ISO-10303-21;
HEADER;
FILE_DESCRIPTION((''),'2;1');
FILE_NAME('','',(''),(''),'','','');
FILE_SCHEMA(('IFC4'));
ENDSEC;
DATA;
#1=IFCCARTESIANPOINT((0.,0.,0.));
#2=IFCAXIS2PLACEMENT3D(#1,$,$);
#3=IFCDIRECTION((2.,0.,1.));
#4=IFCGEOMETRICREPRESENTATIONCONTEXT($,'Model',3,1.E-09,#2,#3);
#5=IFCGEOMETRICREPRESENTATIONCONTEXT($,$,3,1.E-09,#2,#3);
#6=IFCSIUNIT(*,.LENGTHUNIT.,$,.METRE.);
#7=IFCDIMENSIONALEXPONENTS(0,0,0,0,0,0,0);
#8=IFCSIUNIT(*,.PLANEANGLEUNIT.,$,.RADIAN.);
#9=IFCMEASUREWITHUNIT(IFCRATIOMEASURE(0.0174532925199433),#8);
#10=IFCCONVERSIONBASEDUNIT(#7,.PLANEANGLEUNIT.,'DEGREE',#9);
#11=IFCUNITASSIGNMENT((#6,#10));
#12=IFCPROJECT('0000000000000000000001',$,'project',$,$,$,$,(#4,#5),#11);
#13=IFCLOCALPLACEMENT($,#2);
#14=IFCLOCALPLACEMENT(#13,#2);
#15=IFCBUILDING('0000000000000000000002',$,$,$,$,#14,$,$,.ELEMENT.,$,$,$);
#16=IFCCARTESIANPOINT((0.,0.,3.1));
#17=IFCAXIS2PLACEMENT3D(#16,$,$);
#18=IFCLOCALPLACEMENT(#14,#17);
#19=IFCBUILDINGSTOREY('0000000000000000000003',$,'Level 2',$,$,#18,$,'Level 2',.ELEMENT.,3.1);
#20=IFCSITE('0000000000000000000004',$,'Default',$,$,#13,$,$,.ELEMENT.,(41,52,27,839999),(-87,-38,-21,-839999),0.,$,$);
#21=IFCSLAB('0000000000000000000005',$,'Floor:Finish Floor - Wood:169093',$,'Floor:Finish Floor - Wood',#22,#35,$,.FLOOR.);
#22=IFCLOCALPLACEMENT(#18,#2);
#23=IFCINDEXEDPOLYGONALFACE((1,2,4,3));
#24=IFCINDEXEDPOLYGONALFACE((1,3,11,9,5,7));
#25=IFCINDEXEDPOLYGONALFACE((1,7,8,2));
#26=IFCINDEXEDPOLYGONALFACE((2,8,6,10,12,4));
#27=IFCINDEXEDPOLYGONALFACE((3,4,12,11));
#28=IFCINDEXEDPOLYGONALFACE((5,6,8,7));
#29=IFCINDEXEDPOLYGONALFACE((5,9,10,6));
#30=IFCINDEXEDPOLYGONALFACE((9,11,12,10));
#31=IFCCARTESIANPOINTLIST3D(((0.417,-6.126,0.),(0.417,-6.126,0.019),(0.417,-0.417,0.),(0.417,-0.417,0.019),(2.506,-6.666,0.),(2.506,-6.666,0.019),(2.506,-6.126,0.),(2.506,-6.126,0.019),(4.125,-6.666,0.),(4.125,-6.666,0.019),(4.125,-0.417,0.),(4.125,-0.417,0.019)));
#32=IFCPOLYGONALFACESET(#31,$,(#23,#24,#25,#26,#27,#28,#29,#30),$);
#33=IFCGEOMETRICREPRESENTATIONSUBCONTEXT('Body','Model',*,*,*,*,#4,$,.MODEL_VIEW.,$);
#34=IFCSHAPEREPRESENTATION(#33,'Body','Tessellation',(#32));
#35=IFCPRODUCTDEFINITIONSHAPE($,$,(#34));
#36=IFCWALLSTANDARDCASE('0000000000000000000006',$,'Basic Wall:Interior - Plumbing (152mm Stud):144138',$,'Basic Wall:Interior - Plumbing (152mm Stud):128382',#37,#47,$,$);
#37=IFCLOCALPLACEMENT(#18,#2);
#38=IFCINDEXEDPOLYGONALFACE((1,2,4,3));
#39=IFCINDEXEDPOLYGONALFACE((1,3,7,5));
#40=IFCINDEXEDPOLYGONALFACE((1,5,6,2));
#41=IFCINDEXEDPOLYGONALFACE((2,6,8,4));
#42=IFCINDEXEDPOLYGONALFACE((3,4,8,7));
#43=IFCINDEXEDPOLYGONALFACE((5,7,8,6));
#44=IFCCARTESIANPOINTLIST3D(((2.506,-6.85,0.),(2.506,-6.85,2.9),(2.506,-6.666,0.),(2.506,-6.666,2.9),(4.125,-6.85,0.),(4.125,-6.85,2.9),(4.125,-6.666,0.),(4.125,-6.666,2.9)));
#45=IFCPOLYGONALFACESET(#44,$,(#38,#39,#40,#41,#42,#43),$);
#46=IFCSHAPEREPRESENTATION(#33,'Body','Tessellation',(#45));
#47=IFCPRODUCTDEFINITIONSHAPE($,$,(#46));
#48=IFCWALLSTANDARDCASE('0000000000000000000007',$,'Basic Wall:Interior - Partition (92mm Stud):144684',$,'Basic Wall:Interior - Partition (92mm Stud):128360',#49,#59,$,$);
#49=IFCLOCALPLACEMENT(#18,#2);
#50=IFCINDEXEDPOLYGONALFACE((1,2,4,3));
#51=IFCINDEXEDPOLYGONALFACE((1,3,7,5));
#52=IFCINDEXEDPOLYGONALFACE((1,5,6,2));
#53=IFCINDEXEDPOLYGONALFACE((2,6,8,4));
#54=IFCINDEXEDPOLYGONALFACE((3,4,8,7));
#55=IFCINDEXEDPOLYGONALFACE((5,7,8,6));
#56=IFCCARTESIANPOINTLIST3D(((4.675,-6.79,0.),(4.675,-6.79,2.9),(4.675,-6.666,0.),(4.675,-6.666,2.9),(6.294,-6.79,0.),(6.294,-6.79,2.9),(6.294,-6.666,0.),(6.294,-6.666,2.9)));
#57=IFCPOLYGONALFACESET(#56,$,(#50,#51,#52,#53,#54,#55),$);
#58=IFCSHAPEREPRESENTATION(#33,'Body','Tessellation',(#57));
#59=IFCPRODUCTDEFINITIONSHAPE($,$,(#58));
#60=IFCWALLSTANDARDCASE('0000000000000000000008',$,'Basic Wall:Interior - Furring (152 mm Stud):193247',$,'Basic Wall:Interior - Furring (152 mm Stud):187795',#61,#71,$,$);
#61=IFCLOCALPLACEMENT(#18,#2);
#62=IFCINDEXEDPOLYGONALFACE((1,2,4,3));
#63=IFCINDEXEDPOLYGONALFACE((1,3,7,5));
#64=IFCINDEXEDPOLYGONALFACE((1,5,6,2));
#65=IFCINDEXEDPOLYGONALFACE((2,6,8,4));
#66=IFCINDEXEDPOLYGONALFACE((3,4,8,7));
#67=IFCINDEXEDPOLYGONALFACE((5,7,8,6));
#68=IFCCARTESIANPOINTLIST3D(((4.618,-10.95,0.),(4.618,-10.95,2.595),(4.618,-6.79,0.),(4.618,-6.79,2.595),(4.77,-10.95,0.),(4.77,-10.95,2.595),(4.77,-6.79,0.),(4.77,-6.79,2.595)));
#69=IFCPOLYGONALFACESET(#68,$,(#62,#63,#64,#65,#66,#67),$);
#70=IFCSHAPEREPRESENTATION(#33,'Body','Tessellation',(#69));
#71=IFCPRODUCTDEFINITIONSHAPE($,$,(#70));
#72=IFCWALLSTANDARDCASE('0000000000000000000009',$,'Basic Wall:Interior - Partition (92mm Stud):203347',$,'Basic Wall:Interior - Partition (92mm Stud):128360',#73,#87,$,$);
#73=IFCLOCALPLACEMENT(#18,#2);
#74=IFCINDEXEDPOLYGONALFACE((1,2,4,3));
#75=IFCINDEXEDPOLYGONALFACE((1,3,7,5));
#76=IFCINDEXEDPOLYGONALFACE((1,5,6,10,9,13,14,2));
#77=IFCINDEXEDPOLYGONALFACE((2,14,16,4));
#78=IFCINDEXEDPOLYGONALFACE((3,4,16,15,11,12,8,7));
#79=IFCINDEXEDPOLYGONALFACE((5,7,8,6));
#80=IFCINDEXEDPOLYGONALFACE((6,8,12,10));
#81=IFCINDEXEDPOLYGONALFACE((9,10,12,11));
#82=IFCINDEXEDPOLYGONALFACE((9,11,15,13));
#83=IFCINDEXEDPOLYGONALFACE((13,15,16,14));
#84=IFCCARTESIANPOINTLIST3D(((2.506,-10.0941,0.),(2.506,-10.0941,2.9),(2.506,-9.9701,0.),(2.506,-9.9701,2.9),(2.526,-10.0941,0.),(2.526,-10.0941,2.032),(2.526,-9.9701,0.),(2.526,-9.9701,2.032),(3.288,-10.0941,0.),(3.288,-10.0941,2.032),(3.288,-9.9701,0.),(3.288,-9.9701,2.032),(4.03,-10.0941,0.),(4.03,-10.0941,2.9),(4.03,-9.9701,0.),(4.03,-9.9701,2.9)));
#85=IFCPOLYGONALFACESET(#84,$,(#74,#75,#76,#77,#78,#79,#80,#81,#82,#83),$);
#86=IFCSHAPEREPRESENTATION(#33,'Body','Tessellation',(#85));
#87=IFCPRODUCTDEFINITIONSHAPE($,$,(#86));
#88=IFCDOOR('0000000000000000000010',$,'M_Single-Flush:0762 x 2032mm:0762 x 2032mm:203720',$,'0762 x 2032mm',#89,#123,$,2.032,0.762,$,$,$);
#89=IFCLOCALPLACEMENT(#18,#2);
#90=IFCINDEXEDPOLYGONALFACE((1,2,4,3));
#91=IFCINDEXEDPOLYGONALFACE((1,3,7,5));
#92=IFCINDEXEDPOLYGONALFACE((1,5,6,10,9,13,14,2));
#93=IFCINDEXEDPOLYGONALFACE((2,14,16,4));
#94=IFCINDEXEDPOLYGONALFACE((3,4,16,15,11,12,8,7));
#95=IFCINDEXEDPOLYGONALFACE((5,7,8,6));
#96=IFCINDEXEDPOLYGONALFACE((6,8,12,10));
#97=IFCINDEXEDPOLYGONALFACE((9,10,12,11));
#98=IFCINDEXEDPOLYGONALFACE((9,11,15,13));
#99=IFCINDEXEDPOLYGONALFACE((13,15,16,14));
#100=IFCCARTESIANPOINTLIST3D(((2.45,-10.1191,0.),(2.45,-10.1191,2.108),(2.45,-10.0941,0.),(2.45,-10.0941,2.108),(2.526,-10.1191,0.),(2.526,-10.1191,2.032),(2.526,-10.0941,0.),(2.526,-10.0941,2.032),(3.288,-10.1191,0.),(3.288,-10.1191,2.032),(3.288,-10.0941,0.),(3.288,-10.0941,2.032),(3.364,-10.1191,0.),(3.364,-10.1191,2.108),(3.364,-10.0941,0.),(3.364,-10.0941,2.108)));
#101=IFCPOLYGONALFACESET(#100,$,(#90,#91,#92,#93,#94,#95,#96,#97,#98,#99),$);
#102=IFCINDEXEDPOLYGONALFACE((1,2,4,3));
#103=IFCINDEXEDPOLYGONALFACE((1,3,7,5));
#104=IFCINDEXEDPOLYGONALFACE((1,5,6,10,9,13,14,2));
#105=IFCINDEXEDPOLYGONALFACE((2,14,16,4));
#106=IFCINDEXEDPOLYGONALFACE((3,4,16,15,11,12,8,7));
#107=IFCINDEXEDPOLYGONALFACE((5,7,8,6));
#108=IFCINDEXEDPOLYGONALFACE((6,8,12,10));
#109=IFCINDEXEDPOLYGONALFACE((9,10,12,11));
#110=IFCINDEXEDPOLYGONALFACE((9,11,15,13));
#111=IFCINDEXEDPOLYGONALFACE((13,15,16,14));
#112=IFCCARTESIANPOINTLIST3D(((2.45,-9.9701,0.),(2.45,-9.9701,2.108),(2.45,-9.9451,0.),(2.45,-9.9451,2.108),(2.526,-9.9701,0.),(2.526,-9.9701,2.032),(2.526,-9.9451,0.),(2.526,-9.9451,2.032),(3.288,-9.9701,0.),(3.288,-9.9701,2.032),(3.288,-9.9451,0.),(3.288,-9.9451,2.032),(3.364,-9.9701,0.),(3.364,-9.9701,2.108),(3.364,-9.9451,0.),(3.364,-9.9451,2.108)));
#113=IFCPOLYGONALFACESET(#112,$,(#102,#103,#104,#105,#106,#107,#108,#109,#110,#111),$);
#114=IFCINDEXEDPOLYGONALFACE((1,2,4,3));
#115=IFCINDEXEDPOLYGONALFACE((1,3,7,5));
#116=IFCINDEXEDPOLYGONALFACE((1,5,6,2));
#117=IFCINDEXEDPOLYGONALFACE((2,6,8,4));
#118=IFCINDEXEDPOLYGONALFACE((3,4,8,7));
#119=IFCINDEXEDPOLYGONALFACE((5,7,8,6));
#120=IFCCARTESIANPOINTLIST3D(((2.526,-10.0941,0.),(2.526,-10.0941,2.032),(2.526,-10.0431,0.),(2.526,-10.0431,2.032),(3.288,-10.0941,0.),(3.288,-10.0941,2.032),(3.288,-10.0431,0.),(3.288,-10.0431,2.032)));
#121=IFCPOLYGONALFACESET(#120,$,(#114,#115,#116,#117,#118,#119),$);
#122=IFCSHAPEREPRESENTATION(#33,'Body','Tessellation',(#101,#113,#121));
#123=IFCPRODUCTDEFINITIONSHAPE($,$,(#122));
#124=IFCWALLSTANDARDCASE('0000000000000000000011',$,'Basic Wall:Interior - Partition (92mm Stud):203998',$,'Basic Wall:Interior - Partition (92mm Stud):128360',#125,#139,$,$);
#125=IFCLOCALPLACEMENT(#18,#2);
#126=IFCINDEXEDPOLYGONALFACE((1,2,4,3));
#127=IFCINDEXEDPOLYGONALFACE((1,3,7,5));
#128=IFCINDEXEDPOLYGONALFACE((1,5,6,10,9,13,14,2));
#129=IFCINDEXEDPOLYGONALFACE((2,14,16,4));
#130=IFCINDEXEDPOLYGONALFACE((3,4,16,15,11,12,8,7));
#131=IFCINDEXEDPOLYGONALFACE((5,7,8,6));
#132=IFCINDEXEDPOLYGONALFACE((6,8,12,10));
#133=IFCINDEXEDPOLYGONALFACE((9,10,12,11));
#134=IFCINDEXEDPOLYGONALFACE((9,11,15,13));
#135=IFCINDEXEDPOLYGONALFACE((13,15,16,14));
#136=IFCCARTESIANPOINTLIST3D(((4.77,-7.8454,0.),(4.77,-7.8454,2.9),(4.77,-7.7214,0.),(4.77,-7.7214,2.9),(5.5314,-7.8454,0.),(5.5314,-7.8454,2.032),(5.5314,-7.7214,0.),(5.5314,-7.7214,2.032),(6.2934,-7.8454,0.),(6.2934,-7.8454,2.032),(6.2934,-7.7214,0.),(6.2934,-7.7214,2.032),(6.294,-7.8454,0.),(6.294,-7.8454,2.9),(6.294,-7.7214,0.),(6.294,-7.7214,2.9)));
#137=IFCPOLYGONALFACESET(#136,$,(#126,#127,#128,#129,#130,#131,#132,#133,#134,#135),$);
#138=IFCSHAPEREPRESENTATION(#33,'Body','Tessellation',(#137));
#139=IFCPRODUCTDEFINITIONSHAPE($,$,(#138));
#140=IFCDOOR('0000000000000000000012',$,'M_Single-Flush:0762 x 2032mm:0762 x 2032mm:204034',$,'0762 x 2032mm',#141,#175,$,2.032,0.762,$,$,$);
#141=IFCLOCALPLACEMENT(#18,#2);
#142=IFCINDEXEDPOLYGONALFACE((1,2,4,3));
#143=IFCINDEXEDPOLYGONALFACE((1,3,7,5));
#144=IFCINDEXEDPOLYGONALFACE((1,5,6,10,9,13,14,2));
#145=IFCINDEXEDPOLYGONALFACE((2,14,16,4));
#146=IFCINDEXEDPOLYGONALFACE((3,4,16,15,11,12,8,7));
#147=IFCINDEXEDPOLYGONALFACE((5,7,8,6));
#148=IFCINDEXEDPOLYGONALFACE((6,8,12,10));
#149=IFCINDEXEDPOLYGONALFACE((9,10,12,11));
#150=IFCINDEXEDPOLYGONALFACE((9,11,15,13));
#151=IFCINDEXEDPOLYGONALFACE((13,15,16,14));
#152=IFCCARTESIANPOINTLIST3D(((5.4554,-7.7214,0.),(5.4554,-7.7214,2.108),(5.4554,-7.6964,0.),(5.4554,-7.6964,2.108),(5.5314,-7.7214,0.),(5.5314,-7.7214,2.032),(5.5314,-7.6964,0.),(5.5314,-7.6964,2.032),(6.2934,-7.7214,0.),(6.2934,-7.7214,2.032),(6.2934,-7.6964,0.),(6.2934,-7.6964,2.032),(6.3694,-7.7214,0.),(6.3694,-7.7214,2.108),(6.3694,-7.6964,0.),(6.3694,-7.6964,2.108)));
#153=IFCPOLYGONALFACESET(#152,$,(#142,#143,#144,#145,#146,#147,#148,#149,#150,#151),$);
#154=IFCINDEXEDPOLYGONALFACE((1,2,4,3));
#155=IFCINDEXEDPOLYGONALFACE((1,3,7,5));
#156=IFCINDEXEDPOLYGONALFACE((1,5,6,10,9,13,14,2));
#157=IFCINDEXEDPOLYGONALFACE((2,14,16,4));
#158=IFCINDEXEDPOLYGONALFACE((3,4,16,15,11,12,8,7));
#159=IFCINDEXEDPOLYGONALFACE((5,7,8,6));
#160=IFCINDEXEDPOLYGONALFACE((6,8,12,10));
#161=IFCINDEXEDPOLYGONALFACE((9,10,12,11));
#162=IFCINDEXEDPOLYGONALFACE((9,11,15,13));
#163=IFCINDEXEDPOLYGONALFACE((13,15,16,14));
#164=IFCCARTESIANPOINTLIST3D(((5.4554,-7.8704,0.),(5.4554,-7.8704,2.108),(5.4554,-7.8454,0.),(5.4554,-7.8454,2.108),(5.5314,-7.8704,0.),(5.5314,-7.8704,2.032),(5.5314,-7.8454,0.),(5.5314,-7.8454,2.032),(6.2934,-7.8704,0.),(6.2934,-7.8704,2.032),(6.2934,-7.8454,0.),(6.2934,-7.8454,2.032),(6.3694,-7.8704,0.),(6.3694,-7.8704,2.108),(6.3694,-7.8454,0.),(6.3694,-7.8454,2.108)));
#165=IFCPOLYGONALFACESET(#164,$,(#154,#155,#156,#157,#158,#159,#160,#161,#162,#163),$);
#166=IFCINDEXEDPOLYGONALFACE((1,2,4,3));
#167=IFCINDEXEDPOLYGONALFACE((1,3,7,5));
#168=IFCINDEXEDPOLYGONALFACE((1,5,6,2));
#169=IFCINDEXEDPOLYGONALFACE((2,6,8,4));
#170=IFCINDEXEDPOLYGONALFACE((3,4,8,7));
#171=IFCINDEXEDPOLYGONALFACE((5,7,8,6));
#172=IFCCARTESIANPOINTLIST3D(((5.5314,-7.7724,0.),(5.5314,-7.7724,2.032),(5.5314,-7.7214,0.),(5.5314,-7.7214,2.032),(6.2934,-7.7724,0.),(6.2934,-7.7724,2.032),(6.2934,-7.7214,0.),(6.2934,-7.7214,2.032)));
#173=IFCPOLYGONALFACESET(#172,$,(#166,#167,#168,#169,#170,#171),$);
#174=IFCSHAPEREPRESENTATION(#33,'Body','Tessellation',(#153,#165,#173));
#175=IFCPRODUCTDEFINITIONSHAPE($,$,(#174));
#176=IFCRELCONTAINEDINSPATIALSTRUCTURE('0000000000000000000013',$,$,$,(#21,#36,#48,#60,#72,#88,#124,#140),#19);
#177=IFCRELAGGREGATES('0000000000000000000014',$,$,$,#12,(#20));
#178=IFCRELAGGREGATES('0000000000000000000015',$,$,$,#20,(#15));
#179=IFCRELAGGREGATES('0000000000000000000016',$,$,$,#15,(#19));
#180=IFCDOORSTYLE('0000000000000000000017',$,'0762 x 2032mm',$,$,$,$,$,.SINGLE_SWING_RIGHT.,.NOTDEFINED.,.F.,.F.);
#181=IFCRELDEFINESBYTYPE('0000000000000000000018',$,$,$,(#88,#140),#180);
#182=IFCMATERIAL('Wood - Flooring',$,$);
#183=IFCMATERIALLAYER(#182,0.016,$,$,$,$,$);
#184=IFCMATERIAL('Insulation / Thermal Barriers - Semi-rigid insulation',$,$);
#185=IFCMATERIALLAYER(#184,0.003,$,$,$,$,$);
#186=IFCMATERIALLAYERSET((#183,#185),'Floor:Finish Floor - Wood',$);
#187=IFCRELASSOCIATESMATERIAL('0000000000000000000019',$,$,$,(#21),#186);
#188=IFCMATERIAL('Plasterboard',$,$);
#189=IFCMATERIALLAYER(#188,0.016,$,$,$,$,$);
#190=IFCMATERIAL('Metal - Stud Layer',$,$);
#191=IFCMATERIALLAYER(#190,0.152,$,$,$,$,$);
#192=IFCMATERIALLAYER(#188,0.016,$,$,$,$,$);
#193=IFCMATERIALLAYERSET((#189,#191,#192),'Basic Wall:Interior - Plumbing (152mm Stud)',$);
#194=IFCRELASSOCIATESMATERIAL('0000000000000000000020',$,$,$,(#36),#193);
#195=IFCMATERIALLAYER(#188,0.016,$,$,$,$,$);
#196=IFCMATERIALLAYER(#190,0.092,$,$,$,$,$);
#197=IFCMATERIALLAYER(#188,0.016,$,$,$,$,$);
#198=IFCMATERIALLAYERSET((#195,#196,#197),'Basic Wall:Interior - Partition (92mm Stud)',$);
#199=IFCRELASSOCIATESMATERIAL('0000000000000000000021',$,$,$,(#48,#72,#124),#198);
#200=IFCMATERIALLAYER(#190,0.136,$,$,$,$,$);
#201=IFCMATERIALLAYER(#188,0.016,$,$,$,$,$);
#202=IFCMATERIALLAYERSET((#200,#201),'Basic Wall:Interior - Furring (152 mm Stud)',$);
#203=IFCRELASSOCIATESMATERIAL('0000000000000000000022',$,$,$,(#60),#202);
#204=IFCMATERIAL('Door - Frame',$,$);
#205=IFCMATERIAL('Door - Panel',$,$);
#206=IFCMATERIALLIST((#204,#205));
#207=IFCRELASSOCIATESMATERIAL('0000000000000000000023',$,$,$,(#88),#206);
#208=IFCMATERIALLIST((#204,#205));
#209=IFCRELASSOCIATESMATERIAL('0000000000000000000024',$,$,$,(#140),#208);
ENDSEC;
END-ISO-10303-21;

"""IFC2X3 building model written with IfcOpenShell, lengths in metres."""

from ifc_helpers import new_model, entity, si_unit, converted_unit, direction, frame, frame_2d, origin, origin_2d_with_axis, place, context, subcontext, project, spatial, polyline, rectangle, outline, extrude, source, transform, mapped, material, material_list, layer, layer_set, layer_usage, type_object, type_shapes, element, fill, save


model = new_model("IFC2X3")

# Units and contexts
model_context = context("Model", 3, precision=1e-09, world=origin(), true_north=direction((2.0, 0.0, 1.0)))
context_of_model = context(None, 3, precision=1e-09, world=origin(), true_north=direction((2.0, 0.0, 1.0)))
body_context = subcontext(model_context, "Body", "Model", "MODEL_VIEW")
ifc_project = project(units=[si_unit("LENGTHUNIT", "METRE"), converted_unit("PLANEANGLEUNIT", "DEGREE", entity("IfcRatioMeasure", 0.0174532925199433), si_unit("PLANEANGLEUNIT", "RADIAN"), dimensions=[0, 0, 0, 0, 0, 0, 0])], contexts=[model_context, context_of_model])

# Site, building, storey
site_placement = place(None, origin())
site = spatial("IfcSite", under=ifc_project, at=site_placement, Name="Default", CompositionType="ELEMENT", RefLatitude=(41, 52, 27, 839999), RefLongitude=(-87, -38, -21, -839999), RefElevation=0.0)
building_placement = place(site_placement, origin())
building = spatial("IfcBuilding", under=site, at=building_placement, CompositionType="ELEMENT")
storey_placement = place(building_placement, frame((0.0, 0.0, 3.1)))
storey = spatial("IfcBuildingStorey", under=building, at=storey_placement, Name="Level 2", LongName="Level 2", CompositionType="ELEMENT", Elevation=3.1)

# Slab
ifc_material_1 = material(Name="Wood - Flooring")
ifc_layer_1 = layer(ifc_material_1, 0.016)
ifc_material_2 = material(Name="Insulation / Thermal Barriers - Semi-rigid insulation")
ifc_layer_2 = layer(ifc_material_2, 0.003)
ifc_layer_set_1 = layer_set([ifc_layer_1, ifc_layer_2], Name="Floor:Finish Floor - Wood")
ifc_layer_usage_1 = layer_usage(ifc_layer_set_1, "AXIS3", "POSITIVE", 0.0)
slab_placement = place(storey_placement, frame((0.417, -6.666, 0.0)))
element("IfcSlab", 1, at=slab_placement, inside=storey, material=ifc_layer_usage_1, Name="Floor:Finish Floor - Wood:169093", ObjectType="Floor:Finish Floor - Wood", PredefinedType="FLOOR", context=body_context, shape_type="SweptSolid", body=[
    extrude(outline(polyline([(1.854, 3.1245), (-1.854, 3.1245), (-1.854, -3.1245), (-0.235, -3.1245), (-0.235, -2.5845), (1.854, -2.5845), (1.854, 3.1245)])), frame((1.854, 3.1245, 0.019), z_axis=(0.0, 0.0, -1.0), x_axis=(-1.0, 0.0, 0.0)), (0.0, 0.0, 1.0), 0.019),
])

# Walls
ifc_material_3 = material(Name="Plasterboard")
ifc_layer_3 = layer(ifc_material_3, 0.016)
ifc_material_4 = material(Name="Metal - Stud Layer")
ifc_layer_4 = layer(ifc_material_4, 0.152)
ifc_layer_5 = layer(ifc_material_3, 0.016)
ifc_layer_set_2 = layer_set([ifc_layer_3, ifc_layer_4, ifc_layer_5], Name="Basic Wall:Interior - Plumbing (152mm Stud)")
ifc_layer_usage_2 = layer_usage(ifc_layer_set_2, "AXIS2", "NEGATIVE", 0.092)
wall_1_placement = place(storey_placement, frame((2.506, -6.758, 0.0)))
element("IfcWallStandardCase", 2, at=wall_1_placement, inside=storey, material=ifc_layer_usage_2, Name="Basic Wall:Interior - Plumbing (152mm Stud):144138", ObjectType="Basic Wall:Interior - Plumbing (152mm Stud):128382", context=body_context, shape_type="SweptSolid", body=[
    extrude(rectangle(XDim=1.619, YDim=0.184, at=frame_2d((0.8095, 0.0), x_axis=(-1.0, 0.0))), origin(), (0.0, 0.0, 1.0), 2.9),
])
ifc_layer_6 = layer(ifc_material_3, 0.016)
ifc_layer_7 = layer(ifc_material_4, 0.092)
ifc_layer_8 = layer(ifc_material_3, 0.016)
ifc_layer_set_3 = layer_set([ifc_layer_6, ifc_layer_7, ifc_layer_8], Name="Basic Wall:Interior - Partition (92mm Stud)")
ifc_layer_usage_3 = layer_usage(ifc_layer_set_3, "AXIS2", "NEGATIVE", 0.062)
wall_2_placement = place(storey_placement, frame((4.675, -6.728, 0.0)))
element("IfcWallStandardCase", 3, at=wall_2_placement, inside=storey, material=ifc_layer_usage_3, Name="Basic Wall:Interior - Partition (92mm Stud):144684", ObjectType="Basic Wall:Interior - Partition (92mm Stud):128360", context=body_context, shape_type="SweptSolid", body=[
    extrude(rectangle(XDim=1.619, YDim=0.124, at=frame_2d((0.8095, 0.0), x_axis=(-1.0, 0.0))), origin(), (0.0, 0.0, 1.0), 2.9),
])
ifc_layer_9 = layer(ifc_material_4, 0.136)
ifc_layer_10 = layer(ifc_material_3, 0.016)
ifc_layer_set_4 = layer_set([ifc_layer_9, ifc_layer_10], Name="Basic Wall:Interior - Furring (152 mm Stud)")
ifc_layer_usage_4 = layer_usage(ifc_layer_set_4, "AXIS2", "POSITIVE", -0.076)
wall_3_placement = place(storey_placement, frame((4.694, -6.79, 0.0), z_axis=(0.0, 0.0, 1.0), x_axis=(0.0, -1.0, 0.0)))
element("IfcWallStandardCase", 4, at=wall_3_placement, inside=storey, material=ifc_layer_usage_4, Name="Basic Wall:Interior - Furring (152 mm Stud):193247", ObjectType="Basic Wall:Interior - Furring (152 mm Stud):187795", context=body_context, shape_type="SweptSolid", body=[
    extrude(rectangle(XDim=4.16, YDim=0.152, at=frame_2d((2.08, 0.0), x_axis=(-1.0, 0.0))), origin(), (0.0, 0.0, 1.0), 2.595),
])

# Walls, openings, doors
ifc_layer_usage_5 = layer_usage(ifc_layer_set_3, "AXIS2", "NEGATIVE", 0.062)
wall_4_placement = place(storey_placement, frame((4.03, -10.0321, 0.0), z_axis=(0.0, 0.0, 1.0), x_axis=(-1.0, 0.0, 0.0)))
wall_4 = element("IfcWallStandardCase", 5, at=wall_4_placement, inside=storey, material=ifc_layer_usage_5, Name="Basic Wall:Interior - Partition (92mm Stud):203347", ObjectType="Basic Wall:Interior - Partition (92mm Stud):128360", context=body_context, shape_type="SweptSolid", body=[
    extrude(rectangle(XDim=1.524, YDim=0.124, at=frame_2d((0.762, 0.0), x_axis=(-1.0, 0.0))), origin(), (0.0, 0.0, 1.0), 2.9),
])
opening_1_placement = place(wall_4_placement, frame((0.742, -0.062, 0.0)))
opening_1 = element("IfcOpeningElement", 6, at=opening_1_placement, cuts=wall_4, ObjectType="Opening", context=body_context, shape_type="SweptSolid", body=[
    extrude(rectangle(XDim=0.762, YDim=2.032, at=frame_2d((1.016, 0.381), x_axis=(0.0, 1.0))), frame((0.0, 0.0, 0.0), z_axis=(0.0, 1.0, 0.0), x_axis=(0.0, 0.0, 1.0)), (0.0, 0.0, 1.0), 0.124),
])
ifc_material_5 = material(Name="Door - Frame")
ifc_material_6 = material(Name="Door - Panel")
ifc_material_list_1 = material_list([ifc_material_5, ifc_material_6])
door_style = type_object("IfcDoorStyle", Name="0762 x 2032mm", ConstructionType="NOTDEFINED", OperationType="SINGLE_SWING_RIGHT", ParameterTakesPrecedence=False, Sizeable=False)
shared_shape_1 = source(origin(), body_context, "Body", "SweptSolid", [
    extrude(outline(polyline([(-0.457, -1.073), (0.457, -1.073), (0.457, 1.035), (0.381, 1.035), (0.381, -0.997), (-0.381, -0.997), (-0.381, 1.035), (-0.457, 1.035), (-0.457, -1.073)])), frame((0.381, 0.124, 1.035), z_axis=(0.0, 1.0, 0.0), x_axis=(1.0, 0.0, 0.0)), (0.0, 0.0, 1.0), 0.025),
    extrude(outline(polyline([(-1.073, -0.457), (1.035, -0.457), (1.035, -0.381), (-0.997, -0.381), (-0.997, 0.381), (1.035, 0.381), (1.035, 0.457), (-1.073, 0.457), (-1.073, -0.457)])), frame((0.381, -0.025, 1.035), z_axis=(0.0, 1.0, 0.0), x_axis=(0.0, 0.0, -1.0)), (0.0, 0.0, 1.0), 0.025),
    extrude(rectangle(XDim=0.051, YDim=0.762, at=origin_2d_with_axis()), frame((0.381, 0.0985, 0.0), z_axis=(0.0, 0.0, 1.0), x_axis=(0.0, 1.0, 0.0)), (0.0, 0.0, 1.0), 2.032),
])
type_shapes(door_style, [shared_shape_1])
door_1_placement = place(opening_1_placement, origin())
door_1 = element("IfcDoor", 7, at=door_1_placement, inside=storey, type_object=door_style, material=ifc_material_list_1, Name="M_Single-Flush:0762 x 2032mm:0762 x 2032mm:203720", ObjectType="0762 x 2032mm", OverallHeight=2.032, OverallWidth=0.762, context=body_context, shape_type="MappedRepresentation", body=[
    mapped(shared_shape_1, transform((0.0, 0.0, 0.0), scale=1.0)),
])
fill(opening_1, door_1)
ifc_layer_usage_6 = layer_usage(ifc_layer_set_3, "AXIS2", "POSITIVE", -0.062)
wall_5_placement = place(storey_placement, frame((4.77, -7.7834, 0.0)))
wall_5 = element("IfcWallStandardCase", 8, at=wall_5_placement, inside=storey, material=ifc_layer_usage_6, Name="Basic Wall:Interior - Partition (92mm Stud):203998", ObjectType="Basic Wall:Interior - Partition (92mm Stud):128360", context=body_context, shape_type="SweptSolid", body=[
    extrude(rectangle(XDim=1.524, YDim=0.124, at=frame_2d((0.762, 0.0), x_axis=(-1.0, 0.0))), origin(), (0.0, 0.0, 1.0), 2.9),
])
opening_2_placement = place(wall_5_placement, frame((0.7614, -0.062, 0.0)))
opening_2 = element("IfcOpeningElement", 9, at=opening_2_placement, cuts=wall_5, ObjectType="Opening", context=body_context, shape_type="SweptSolid", body=[
    extrude(rectangle(XDim=0.762, YDim=2.032, at=frame_2d((1.016, 0.381), x_axis=(0.0, 1.0))), frame((0.0, 0.0, 0.0), z_axis=(0.0, 1.0, 0.0), x_axis=(0.0, 0.0, 1.0)), (0.0, 0.0, 1.0), 0.124),
])
ifc_material_list_2 = material_list([ifc_material_5, ifc_material_6])
door_2_placement = place(opening_2_placement, origin())
door_2 = element("IfcDoor", 10, at=door_2_placement, inside=storey, type_object=door_style, material=ifc_material_list_2, Name="M_Single-Flush:0762 x 2032mm:0762 x 2032mm:204034", ObjectType="0762 x 2032mm", OverallHeight=2.032, OverallWidth=0.762, context=body_context, shape_type="MappedRepresentation", body=[
    mapped(shared_shape_1, transform((0.0, 0.0, 0.0), scale=1.0)),
])
fill(opening_2, door_2)

save(model, "model.ifc")
